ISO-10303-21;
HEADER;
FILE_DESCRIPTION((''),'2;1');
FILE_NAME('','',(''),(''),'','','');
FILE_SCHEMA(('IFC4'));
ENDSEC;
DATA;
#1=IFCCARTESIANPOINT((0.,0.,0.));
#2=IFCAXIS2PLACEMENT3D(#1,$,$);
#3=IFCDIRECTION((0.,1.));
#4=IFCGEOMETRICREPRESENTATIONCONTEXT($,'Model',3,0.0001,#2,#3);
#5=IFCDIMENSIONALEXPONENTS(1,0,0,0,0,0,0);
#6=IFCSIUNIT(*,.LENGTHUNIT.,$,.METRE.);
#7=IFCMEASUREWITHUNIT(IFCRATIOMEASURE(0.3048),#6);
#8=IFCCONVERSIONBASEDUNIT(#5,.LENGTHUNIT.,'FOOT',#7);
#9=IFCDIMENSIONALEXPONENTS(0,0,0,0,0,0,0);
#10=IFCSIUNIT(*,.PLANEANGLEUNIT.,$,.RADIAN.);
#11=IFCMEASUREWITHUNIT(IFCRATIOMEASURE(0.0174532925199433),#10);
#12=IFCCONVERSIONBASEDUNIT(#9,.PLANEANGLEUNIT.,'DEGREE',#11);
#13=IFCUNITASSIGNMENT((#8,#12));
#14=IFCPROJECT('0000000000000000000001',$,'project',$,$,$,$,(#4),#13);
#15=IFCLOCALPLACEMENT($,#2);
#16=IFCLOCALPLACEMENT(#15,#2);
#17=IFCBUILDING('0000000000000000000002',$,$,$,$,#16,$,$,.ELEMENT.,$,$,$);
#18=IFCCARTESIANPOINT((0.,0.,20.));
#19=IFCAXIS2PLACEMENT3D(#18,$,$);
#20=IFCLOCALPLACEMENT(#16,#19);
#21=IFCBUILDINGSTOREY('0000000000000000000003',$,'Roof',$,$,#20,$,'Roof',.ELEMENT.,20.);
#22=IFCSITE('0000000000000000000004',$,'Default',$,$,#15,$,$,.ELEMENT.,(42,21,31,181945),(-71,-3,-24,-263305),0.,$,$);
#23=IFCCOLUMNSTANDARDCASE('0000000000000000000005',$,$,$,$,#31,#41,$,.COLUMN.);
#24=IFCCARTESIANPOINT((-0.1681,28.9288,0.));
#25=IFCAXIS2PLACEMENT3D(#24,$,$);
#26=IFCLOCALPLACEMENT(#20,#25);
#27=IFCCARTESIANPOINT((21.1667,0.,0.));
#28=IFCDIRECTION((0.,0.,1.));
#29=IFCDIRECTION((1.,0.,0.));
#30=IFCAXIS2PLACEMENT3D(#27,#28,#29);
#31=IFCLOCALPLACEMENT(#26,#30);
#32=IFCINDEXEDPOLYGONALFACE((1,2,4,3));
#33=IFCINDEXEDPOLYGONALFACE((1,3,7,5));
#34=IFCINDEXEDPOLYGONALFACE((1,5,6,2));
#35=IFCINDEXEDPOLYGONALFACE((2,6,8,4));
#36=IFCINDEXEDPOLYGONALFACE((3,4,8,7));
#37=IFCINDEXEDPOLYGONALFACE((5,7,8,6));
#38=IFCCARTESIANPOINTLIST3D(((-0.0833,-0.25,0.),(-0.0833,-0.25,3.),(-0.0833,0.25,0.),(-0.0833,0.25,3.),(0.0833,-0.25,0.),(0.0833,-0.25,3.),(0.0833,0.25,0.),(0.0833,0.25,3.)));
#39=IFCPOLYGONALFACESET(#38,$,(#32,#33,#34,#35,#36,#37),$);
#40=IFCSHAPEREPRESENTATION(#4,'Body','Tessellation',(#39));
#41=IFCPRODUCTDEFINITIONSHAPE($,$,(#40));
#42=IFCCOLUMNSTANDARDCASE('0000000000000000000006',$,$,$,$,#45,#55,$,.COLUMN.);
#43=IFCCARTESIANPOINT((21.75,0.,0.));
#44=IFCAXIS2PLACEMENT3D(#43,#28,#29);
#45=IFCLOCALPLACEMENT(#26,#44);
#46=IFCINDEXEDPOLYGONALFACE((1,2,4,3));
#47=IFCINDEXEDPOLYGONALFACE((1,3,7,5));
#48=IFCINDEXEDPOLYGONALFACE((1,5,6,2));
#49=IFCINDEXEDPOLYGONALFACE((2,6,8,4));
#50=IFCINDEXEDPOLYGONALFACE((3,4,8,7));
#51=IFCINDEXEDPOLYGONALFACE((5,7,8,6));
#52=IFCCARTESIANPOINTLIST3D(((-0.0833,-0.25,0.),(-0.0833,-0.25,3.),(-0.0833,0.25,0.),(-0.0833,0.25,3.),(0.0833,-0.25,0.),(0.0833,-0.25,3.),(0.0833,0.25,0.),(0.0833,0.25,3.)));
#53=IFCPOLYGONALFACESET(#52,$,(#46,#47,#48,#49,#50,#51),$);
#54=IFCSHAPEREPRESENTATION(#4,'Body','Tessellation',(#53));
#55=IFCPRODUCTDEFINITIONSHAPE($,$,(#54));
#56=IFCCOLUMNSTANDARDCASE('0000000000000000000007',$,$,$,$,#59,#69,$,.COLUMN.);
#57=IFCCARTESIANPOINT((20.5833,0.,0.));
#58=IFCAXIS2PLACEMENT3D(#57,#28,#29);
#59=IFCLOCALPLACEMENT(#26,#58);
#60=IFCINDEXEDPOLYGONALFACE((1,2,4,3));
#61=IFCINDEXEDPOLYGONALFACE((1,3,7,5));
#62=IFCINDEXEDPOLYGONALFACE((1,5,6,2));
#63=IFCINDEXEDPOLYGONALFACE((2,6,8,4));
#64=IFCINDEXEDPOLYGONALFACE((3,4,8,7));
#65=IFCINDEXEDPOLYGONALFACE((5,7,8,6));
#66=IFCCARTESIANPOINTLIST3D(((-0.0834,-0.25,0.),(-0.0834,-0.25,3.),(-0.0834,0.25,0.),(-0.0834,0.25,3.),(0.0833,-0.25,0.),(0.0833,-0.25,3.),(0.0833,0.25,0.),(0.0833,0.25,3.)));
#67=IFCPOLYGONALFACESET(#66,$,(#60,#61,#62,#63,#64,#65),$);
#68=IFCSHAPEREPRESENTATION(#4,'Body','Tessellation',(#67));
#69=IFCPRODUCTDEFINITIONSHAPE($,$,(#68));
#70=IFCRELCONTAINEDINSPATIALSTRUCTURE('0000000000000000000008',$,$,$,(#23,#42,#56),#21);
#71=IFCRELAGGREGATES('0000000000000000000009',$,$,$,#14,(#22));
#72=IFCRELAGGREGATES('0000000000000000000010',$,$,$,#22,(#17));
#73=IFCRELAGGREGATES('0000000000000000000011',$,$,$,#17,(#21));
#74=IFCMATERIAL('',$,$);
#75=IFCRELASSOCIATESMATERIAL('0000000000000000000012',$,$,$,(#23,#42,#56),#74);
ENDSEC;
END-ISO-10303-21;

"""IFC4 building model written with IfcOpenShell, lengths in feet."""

from ifc_helpers import new_model, entity, si_unit, converted_unit, direction, frame, origin, place, context, project, spatial, rectangle, extrude, material, element, save


model = new_model("IFC4")

# Units and contexts
model_context = context("Model", 3, precision=0.0001, world=origin(), true_north=direction((0.0, 1.0)))
ifc_project = project(units=[converted_unit("LENGTHUNIT", "FOOT", entity("IfcRatioMeasure", 0.3048), si_unit("LENGTHUNIT", "METRE"), dimensions=[1, 0, 0, 0, 0, 0, 0]), converted_unit("PLANEANGLEUNIT", "DEGREE", entity("IfcRatioMeasure", 0.0174532925199433), si_unit("PLANEANGLEUNIT", "RADIAN"), dimensions=[0, 0, 0, 0, 0, 0, 0])], contexts=[model_context])

# Site, building, storey
site_placement = place(None, origin())
site = spatial("IfcSite", under=ifc_project, at=site_placement, Name="Default", CompositionType="ELEMENT", RefLatitude=(42, 21, 31, 181945), RefLongitude=(-71, -3, -24, -263305), RefElevation=0.0)
building_placement = place(site_placement, origin())
building = spatial("IfcBuilding", under=site, at=building_placement, CompositionType="ELEMENT")
storey_placement = place(building_placement, frame((0.0, 0.0, 20.0)))
storey = spatial("IfcBuildingStorey", under=building, at=storey_placement, Name="Roof", LongName="Roof", CompositionType="ELEMENT", Elevation=20.0)

# Columns
ifc_material = material(Name="")
placement = place(storey_placement, frame((-0.1681, 28.9288, 0.0)))
for number, where, z_axis, x_axis in (
    (1, (21.1667, 0.0, 0.0), (0.0, 0.0, 1.0), (1.0, 0.0, 0.0)),
    (2, (21.75, 0.0, 0.0), (0.0, 0.0, 1.0), (1.0, 0.0, 0.0)),
    (3, (20.5833, 0.0, 0.0), (0.0, 0.0, 1.0), (1.0, 0.0, 0.0)),
):
    element("IfcColumnStandardCase", number, at=place(placement, frame(where, z_axis=z_axis, x_axis=x_axis)), inside=storey, material=ifc_material, PredefinedType="COLUMN", context=model_context, shape_type="SweptSolid", body=[
        extrude(rectangle(XDim=0.1667, YDim=0.5), origin(), (0.0, 0.0, 1.0), 3.0),
    ])

save(model, "model.ifc")
